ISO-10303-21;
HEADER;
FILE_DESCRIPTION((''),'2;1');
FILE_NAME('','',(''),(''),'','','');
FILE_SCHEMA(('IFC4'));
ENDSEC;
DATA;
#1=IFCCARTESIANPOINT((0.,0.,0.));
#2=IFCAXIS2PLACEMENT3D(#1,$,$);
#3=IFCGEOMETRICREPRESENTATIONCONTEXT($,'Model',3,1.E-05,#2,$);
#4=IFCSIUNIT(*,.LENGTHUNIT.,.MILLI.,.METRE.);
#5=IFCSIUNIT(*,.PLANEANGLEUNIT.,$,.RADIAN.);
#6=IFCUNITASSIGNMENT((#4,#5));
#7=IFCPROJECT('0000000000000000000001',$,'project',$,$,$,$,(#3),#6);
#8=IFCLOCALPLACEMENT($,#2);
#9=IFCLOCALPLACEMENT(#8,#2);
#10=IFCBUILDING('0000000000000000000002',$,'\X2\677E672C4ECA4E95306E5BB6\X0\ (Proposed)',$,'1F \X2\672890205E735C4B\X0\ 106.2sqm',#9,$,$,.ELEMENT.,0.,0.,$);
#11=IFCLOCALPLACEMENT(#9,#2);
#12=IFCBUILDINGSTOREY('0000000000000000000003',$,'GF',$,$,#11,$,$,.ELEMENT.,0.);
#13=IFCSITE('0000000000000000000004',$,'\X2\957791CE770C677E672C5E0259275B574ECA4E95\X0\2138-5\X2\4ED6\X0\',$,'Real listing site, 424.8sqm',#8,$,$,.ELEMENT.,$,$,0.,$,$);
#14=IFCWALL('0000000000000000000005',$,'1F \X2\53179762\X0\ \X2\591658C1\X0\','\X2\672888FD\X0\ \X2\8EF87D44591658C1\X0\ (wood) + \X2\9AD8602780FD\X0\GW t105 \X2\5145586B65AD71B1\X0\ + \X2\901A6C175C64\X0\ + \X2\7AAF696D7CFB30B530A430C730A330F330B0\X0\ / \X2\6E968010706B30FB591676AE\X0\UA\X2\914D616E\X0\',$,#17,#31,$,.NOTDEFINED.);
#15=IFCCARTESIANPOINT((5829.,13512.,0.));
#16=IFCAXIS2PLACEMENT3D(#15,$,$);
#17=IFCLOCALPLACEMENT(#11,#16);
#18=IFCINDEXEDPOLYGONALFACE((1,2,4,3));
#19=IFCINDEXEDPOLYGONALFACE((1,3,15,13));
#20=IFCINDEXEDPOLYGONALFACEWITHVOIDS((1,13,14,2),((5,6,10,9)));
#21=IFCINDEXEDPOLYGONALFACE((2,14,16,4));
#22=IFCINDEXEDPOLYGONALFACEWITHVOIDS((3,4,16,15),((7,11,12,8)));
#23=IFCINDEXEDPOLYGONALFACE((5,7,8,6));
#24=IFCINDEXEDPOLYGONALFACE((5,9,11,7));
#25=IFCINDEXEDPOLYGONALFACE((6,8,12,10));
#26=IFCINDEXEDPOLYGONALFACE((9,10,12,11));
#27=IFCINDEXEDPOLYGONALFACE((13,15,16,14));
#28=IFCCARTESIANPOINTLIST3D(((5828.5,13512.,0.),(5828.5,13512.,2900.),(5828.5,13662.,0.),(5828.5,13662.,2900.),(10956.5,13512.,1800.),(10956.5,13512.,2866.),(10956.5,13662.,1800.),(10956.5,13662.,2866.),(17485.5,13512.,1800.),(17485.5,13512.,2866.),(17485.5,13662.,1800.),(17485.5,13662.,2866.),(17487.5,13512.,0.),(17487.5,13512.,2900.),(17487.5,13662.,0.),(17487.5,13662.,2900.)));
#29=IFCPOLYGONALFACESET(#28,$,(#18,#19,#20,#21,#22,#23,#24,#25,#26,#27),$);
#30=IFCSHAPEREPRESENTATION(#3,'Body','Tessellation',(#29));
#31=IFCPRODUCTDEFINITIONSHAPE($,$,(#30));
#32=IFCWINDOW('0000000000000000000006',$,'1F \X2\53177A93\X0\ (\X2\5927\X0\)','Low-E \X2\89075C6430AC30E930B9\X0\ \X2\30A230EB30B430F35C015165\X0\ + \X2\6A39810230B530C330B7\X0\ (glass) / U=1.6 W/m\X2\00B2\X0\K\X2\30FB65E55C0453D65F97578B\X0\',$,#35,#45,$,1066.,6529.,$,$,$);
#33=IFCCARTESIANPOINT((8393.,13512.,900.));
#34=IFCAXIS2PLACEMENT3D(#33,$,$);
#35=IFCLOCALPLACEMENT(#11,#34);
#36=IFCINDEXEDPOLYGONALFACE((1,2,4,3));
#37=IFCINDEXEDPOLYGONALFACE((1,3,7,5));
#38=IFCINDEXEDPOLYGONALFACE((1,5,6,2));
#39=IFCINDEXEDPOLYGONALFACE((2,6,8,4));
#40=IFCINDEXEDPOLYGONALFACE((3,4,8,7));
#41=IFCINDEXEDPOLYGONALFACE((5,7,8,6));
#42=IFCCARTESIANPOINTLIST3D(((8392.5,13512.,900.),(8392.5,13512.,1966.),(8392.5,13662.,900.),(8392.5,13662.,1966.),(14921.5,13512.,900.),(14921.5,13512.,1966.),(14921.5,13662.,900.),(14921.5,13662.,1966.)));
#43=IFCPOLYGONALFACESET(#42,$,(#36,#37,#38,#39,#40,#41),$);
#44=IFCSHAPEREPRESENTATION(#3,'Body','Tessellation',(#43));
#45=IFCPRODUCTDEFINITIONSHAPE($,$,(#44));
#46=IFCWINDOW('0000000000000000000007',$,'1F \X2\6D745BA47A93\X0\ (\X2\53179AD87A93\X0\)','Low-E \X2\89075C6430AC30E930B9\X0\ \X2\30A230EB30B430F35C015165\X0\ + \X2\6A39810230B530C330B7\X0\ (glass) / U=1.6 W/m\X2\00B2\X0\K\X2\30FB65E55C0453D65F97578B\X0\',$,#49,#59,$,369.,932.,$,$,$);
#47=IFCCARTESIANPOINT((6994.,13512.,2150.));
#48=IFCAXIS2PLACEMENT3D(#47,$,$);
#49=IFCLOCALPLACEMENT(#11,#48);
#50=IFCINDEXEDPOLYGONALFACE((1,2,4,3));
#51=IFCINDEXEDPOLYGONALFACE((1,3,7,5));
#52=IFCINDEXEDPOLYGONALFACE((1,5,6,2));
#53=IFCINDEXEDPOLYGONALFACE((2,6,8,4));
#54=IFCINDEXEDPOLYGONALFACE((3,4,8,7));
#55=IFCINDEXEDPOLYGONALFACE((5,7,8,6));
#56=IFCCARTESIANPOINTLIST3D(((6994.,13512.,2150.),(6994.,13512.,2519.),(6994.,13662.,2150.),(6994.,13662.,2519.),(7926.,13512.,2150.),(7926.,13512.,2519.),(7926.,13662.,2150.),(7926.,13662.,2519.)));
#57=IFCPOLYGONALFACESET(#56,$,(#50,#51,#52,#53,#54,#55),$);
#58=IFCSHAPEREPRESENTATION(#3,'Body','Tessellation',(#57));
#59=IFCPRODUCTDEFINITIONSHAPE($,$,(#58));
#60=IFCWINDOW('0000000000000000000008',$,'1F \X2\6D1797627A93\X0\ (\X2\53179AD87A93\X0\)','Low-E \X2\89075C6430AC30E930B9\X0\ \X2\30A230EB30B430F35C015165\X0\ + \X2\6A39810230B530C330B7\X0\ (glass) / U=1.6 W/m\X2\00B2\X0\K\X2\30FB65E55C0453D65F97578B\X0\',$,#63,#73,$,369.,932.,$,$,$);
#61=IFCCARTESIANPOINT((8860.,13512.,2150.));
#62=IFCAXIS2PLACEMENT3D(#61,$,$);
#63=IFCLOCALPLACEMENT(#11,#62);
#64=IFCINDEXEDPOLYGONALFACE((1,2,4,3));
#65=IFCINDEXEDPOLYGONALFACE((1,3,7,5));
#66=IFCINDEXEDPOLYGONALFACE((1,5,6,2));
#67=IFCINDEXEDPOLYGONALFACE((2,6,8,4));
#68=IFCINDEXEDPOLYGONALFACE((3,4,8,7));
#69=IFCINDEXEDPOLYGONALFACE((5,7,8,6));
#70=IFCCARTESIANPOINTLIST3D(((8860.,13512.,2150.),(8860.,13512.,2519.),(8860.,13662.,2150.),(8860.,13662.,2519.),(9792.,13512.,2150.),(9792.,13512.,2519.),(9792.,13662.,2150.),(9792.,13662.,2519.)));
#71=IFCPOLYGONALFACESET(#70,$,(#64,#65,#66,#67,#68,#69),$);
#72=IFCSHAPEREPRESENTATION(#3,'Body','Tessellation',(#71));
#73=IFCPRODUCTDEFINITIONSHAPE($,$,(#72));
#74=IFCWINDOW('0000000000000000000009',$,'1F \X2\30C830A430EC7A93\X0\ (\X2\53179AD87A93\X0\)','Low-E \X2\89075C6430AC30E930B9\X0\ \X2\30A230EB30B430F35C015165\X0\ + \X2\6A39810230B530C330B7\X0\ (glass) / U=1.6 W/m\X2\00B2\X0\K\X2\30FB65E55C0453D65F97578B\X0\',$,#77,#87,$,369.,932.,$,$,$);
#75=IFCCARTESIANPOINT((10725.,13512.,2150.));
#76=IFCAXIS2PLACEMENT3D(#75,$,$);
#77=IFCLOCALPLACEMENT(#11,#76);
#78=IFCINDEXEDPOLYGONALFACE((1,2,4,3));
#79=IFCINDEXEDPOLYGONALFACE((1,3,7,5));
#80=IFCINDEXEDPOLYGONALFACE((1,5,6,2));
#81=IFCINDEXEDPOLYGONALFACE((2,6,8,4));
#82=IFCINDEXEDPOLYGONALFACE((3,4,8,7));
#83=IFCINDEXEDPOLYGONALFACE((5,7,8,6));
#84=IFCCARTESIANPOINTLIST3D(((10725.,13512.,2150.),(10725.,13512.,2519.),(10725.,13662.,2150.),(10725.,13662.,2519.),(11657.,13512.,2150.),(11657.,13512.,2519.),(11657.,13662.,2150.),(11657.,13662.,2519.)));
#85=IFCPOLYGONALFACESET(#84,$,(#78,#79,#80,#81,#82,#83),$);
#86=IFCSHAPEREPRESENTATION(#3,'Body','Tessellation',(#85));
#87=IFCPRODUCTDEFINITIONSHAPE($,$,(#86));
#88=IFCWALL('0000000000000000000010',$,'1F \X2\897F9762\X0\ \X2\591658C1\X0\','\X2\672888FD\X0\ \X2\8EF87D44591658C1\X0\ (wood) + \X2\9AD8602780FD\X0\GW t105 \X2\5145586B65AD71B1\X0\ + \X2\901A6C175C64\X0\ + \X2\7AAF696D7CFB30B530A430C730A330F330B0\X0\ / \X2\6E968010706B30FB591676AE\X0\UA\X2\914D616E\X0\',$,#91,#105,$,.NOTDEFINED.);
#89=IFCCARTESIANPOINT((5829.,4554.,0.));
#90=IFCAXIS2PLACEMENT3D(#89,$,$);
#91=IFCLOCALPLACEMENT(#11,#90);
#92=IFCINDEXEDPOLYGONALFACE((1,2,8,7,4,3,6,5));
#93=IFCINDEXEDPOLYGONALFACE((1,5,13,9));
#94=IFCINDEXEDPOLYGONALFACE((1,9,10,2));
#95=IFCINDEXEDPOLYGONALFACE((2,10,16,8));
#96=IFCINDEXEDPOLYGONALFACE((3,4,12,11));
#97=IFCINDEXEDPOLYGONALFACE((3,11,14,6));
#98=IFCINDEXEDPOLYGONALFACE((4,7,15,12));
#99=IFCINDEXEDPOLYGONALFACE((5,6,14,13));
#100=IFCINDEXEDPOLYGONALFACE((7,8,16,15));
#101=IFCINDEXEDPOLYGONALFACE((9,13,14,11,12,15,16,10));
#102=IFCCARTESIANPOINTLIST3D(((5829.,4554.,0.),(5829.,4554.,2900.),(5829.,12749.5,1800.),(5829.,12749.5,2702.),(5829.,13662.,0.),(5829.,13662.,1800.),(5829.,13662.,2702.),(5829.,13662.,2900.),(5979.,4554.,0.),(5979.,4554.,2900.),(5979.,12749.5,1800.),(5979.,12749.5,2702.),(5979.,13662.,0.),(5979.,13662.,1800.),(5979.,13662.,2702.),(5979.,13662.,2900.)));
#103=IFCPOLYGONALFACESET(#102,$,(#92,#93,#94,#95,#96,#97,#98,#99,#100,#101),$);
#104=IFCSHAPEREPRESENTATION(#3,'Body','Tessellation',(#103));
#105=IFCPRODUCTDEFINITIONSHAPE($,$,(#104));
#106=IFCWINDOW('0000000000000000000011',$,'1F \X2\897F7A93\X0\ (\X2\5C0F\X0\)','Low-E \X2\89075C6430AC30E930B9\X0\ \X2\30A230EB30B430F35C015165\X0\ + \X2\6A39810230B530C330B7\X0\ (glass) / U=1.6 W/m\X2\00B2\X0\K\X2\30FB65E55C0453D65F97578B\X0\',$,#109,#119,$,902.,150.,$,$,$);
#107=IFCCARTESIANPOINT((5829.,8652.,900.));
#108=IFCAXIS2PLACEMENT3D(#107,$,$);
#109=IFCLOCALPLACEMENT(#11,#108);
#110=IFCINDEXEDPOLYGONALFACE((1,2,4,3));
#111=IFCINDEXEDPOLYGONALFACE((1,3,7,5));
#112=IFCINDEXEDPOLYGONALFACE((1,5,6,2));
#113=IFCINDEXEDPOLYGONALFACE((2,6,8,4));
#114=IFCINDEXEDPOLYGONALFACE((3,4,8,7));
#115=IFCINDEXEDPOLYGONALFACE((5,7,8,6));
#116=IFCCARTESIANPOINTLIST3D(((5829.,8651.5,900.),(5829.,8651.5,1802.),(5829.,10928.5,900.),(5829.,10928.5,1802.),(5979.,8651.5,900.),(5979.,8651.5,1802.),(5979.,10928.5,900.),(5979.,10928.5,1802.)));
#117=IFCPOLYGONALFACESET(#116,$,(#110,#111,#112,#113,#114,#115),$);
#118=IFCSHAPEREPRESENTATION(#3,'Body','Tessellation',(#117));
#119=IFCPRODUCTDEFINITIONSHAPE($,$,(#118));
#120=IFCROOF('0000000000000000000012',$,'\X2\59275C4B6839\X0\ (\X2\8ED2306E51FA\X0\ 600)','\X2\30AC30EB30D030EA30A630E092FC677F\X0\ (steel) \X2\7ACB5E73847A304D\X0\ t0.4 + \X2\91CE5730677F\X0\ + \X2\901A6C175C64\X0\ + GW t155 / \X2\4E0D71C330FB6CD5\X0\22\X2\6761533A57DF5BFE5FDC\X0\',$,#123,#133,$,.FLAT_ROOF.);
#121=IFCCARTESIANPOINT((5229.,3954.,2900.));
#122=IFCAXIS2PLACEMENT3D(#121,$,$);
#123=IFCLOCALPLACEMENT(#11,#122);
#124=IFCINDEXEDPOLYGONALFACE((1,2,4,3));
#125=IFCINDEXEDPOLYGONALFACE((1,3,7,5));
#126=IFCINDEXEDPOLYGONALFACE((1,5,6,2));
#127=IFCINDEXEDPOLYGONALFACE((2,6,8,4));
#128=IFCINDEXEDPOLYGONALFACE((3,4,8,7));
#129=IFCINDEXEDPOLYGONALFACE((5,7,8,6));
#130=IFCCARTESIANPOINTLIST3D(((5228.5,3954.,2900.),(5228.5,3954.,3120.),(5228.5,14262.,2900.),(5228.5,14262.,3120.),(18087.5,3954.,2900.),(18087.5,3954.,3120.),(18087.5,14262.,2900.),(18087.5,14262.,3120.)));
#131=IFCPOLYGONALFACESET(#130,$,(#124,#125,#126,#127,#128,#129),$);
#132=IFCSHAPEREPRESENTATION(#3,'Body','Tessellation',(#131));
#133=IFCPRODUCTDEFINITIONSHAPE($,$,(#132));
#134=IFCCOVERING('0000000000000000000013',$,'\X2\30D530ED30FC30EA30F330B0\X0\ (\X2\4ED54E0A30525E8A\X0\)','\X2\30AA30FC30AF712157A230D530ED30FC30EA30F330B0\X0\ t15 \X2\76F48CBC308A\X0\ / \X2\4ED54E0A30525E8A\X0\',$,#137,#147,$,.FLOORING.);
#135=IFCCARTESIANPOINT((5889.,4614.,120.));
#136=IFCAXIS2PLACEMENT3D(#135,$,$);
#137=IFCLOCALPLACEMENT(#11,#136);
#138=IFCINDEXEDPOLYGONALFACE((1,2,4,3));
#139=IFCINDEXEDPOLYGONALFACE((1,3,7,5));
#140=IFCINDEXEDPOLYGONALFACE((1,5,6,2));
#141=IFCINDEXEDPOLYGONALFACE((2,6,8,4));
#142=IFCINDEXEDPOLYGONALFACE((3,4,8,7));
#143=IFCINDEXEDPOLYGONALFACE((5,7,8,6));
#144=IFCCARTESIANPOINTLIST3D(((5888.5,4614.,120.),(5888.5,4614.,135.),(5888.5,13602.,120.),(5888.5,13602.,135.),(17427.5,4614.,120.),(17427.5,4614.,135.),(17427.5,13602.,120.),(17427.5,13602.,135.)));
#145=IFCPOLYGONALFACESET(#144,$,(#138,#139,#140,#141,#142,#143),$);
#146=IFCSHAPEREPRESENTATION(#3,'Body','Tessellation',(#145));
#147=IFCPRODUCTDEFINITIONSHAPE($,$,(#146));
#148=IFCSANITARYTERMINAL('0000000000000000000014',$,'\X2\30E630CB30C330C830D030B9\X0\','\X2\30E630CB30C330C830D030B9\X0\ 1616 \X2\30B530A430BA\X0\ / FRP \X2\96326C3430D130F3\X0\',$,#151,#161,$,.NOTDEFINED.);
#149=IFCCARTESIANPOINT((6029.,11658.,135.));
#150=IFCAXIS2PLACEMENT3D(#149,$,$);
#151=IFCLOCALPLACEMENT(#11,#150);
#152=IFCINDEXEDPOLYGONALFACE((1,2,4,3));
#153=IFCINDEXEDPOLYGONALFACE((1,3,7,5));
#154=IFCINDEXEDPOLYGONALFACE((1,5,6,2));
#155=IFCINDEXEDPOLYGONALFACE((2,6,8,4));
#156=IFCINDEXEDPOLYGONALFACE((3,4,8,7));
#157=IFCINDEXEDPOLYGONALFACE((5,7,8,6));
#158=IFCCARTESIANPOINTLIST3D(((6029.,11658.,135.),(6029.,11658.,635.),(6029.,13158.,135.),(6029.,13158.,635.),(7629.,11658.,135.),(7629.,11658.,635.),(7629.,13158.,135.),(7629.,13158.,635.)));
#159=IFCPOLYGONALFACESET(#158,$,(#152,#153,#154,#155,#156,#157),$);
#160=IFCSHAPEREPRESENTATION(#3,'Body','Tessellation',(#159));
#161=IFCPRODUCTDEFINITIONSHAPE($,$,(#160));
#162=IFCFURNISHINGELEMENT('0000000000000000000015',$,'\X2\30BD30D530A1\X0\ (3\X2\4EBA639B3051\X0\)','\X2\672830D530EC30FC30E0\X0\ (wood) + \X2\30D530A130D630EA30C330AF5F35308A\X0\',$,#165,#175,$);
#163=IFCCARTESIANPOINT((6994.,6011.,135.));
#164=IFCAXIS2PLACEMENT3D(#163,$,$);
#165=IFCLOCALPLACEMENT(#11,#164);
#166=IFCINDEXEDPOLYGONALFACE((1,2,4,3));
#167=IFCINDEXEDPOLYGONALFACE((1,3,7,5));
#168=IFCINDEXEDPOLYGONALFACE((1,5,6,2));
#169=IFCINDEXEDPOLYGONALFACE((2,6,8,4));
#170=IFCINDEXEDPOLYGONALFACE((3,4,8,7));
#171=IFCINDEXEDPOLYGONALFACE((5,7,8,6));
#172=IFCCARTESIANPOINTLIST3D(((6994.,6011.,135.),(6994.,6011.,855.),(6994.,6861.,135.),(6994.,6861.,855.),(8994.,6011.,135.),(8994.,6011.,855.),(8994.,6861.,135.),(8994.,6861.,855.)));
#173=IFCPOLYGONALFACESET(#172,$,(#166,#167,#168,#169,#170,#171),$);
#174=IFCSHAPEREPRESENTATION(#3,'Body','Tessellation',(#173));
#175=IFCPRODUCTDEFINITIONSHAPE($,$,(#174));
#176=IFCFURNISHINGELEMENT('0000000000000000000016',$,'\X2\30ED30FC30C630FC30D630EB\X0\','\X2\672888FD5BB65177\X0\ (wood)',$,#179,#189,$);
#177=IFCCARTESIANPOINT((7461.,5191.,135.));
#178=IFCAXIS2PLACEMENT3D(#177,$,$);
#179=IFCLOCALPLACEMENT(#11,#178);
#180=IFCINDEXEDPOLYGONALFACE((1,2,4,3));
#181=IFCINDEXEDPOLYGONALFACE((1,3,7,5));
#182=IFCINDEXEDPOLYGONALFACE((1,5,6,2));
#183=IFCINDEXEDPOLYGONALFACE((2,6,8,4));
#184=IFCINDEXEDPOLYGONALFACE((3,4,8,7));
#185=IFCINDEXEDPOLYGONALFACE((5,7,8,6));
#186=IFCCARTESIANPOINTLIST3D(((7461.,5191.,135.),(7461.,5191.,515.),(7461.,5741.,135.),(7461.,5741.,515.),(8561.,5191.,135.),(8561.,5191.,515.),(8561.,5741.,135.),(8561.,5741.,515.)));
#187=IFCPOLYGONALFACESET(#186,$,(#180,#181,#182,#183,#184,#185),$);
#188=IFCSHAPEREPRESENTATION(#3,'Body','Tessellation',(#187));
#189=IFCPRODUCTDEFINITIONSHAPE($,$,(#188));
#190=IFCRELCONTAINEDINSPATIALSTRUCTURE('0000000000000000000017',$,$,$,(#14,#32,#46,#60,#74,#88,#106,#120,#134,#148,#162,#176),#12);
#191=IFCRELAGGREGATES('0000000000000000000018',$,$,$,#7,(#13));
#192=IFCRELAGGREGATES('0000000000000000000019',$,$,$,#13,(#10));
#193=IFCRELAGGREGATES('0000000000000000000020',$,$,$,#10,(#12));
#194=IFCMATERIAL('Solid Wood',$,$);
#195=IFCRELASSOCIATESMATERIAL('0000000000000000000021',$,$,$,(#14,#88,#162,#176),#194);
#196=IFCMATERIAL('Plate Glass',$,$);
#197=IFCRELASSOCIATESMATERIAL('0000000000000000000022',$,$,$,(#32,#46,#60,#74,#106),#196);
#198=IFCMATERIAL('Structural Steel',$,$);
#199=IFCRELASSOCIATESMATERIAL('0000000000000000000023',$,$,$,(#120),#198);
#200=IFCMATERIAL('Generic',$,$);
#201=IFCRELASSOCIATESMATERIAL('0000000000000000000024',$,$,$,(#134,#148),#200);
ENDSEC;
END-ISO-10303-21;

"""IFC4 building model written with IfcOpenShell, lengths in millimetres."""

from ifc_helpers import new_model, si_unit, frame, frame_2d, origin, place, context, project, spatial, rectangle, extrude, material, element, fill, save


model = new_model("IFC4")

# Units and contexts
model_context = context("Model", 3, precision=1e-05, world=origin())
ifc_project = project(units=[si_unit("LENGTHUNIT", "METRE", prefix="MILLI"), si_unit("PLANEANGLEUNIT", "RADIAN")], contexts=[model_context])

# Site, building, storey
site_placement = place(None, origin())
site = spatial("IfcSite", under=ifc_project, at=site_placement, Name="長野県松本市大字今井2138-5他", ObjectType="Real listing site, 424.8sqm", CompositionType="ELEMENT", RefElevation=0.0)
building_placement = place(site_placement, origin())
building = spatial("IfcBuilding", under=site, at=building_placement, Name="松本今井の家 (Proposed)", ObjectType="1F 木造平屋 106.2sqm", CompositionType="ELEMENT", ElevationOfRefHeight=0.0, ElevationOfTerrain=0.0)
storey_placement = place(building_placement, origin())
storey = spatial("IfcBuildingStorey", under=building, at=storey_placement, Name="GF", CompositionType="ELEMENT", Elevation=0.0)

# Shared definitions
ifc_material_1 = material(Name="Solid Wood")

# Shared definitions
ifc_material_2 = material(Name="Plate Glass")

# Wall, openings, windows
wall_1_placement = place(storey_placement, frame((5829.0, 13512.0, 0.0)))
wall_1 = element("IfcWall", 1, at=wall_1_placement, inside=storey, material=ifc_material_1, Name="1F 北面 外壁", Description="木製 軸組外壁 (wood) + 高性能GW t105 充填断熱 + 通気層 + 窯業系サイディング / 準耐火・外皮UA配慮", PredefinedType="NOTDEFINED", context=model_context, shape_type="SweptSolid", body=[
    extrude(rectangle(XDim=11659.0, YDim=150.0, at=frame_2d((5829.0, 75.0))), frame((5829.0, 13512.0, 0.0)), (0.0, 0.0, 1.0), 2900.0),
])
opening_1_placement = place(storey_placement, frame((8393.0, 13512.0, 900.0)))
opening_1 = element("IfcOpeningElement", 2, at=opening_1_placement, cuts=wall_1, PredefinedType="NOTDEFINED", context=model_context, shape_type="SweptSolid", body=[
    extrude(rectangle(XDim=6529.0, YDim=150.0, at=frame_2d((3264.0, 75.0))), frame((8393.0, 13512.0, 900.0)), (0.0, 0.0, 1.0), 1066.0),
])
opening_2_placement = place(storey_placement, frame((6994.0, 13512.0, 2150.0)))
opening_2 = element("IfcOpeningElement", 3, at=opening_2_placement, cuts=wall_1, PredefinedType="NOTDEFINED", context=model_context, shape_type="SweptSolid", body=[
    extrude(rectangle(XDim=932.0, YDim=150.0, at=frame_2d((466.0, 75.0))), frame((6994.0, 13512.0, 2150.0)), (0.0, 0.0, 1.0), 369.0),
])
opening_3_placement = place(storey_placement, frame((8860.0, 13512.0, 2150.0)))
opening_3 = element("IfcOpeningElement", 4, at=opening_3_placement, cuts=wall_1, PredefinedType="NOTDEFINED", context=model_context, shape_type="SweptSolid", body=[
    extrude(rectangle(XDim=932.0, YDim=150.0, at=frame_2d((466.0, 75.0))), frame((8860.0, 13512.0, 2150.0)), (0.0, 0.0, 1.0), 369.0),
])
opening_4_placement = place(storey_placement, frame((10725.0, 13512.0, 2150.0)))
opening_4 = element("IfcOpeningElement", 5, at=opening_4_placement, cuts=wall_1, PredefinedType="NOTDEFINED", context=model_context, shape_type="SweptSolid", body=[
    extrude(rectangle(XDim=932.0, YDim=150.0, at=frame_2d((466.0, 75.0))), frame((10725.0, 13512.0, 2150.0)), (0.0, 0.0, 1.0), 369.0),
])
window_1_placement = place(storey_placement, frame((8393.0, 13512.0, 900.0)))
window_1 = element("IfcWindow", 6, at=window_1_placement, inside=storey, material=ifc_material_2, Name="1F 北窓 (大)", Description="Low-E 複層ガラス アルゴン封入 + 樹脂サッシ (glass) / U=1.6 W/m²K・日射取得型", OverallHeight=1066.0, OverallWidth=6529.0, context=model_context, shape_type="SweptSolid", body=[
    extrude(rectangle(XDim=6529.0, YDim=150.0, at=frame_2d((3264.0, 75.0))), frame((8393.0, 13512.0, 900.0)), (0.0, 0.0, 1.0), 1066.0),
])
fill(opening_1, window_1)
window_2_placement = place(storey_placement, frame((6994.0, 13512.0, 2150.0)))
window_2 = element("IfcWindow", 7, at=window_2_placement, inside=storey, material=ifc_material_2, Name="1F 浴室窓 (北高窓)", Description="Low-E 複層ガラス アルゴン封入 + 樹脂サッシ (glass) / U=1.6 W/m²K・日射取得型", OverallHeight=369.0, OverallWidth=932.0, context=model_context, shape_type="SweptSolid", body=[
    extrude(rectangle(XDim=932.0, YDim=150.0, at=frame_2d((466.0, 75.0))), frame((6994.0, 13512.0, 2150.0)), (0.0, 0.0, 1.0), 369.0),
])
fill(opening_2, window_2)
window_3_placement = place(storey_placement, frame((8860.0, 13512.0, 2150.0)))
window_3 = element("IfcWindow", 8, at=window_3_placement, inside=storey, material=ifc_material_2, Name="1F 洗面窓 (北高窓)", Description="Low-E 複層ガラス アルゴン封入 + 樹脂サッシ (glass) / U=1.6 W/m²K・日射取得型", OverallHeight=369.0, OverallWidth=932.0, context=model_context, shape_type="SweptSolid", body=[
    extrude(rectangle(XDim=932.0, YDim=150.0, at=frame_2d((466.0, 75.0))), frame((8860.0, 13512.0, 2150.0)), (0.0, 0.0, 1.0), 369.0),
])
fill(opening_3, window_3)
window_4_placement = place(storey_placement, frame((10725.0, 13512.0, 2150.0)))
window_4 = element("IfcWindow", 9, at=window_4_placement, inside=storey, material=ifc_material_2, Name="1F トイレ窓 (北高窓)", Description="Low-E 複層ガラス アルゴン封入 + 樹脂サッシ (glass) / U=1.6 W/m²K・日射取得型", OverallHeight=369.0, OverallWidth=932.0, context=model_context, shape_type="SweptSolid", body=[
    extrude(rectangle(XDim=932.0, YDim=150.0, at=frame_2d((466.0, 75.0))), frame((10725.0, 13512.0, 2150.0)), (0.0, 0.0, 1.0), 369.0),
])
fill(opening_4, window_4)

# Wall, opening, window
wall_2_placement = place(storey_placement, frame((5829.0, 4554.0, 0.0)))
wall_2 = element("IfcWall", 10, at=wall_2_placement, inside=storey, material=ifc_material_1, Name="1F 西面 外壁", Description="木製 軸組外壁 (wood) + 高性能GW t105 充填断熱 + 通気層 + 窯業系サイディング / 準耐火・外皮UA配慮", PredefinedType="NOTDEFINED", context=model_context, shape_type="SweptSolid", body=[
    extrude(rectangle(XDim=150.0, YDim=9108.0, at=frame_2d((75.0, 4554.0))), frame((5829.0, 4554.0, 0.0)), (0.0, 0.0, 1.0), 2900.0),
])
opening_5_placement = place(storey_placement, frame((5829.0, 8652.0, 900.0)))
opening_5 = element("IfcOpeningElement", 11, at=opening_5_placement, cuts=wall_2, PredefinedType="NOTDEFINED", context=model_context, shape_type="SweptSolid", body=[
    extrude(rectangle(XDim=150.0, YDim=2277.0, at=frame_2d((75.0, 1138.0))), frame((5829.0, 8652.0, 900.0)), (0.0, 0.0, 1.0), 902.0),
])
window_5_placement = place(storey_placement, frame((5829.0, 8652.0, 900.0)))
window_5 = element("IfcWindow", 12, at=window_5_placement, inside=storey, material=ifc_material_2, Name="1F 西窓 (小)", Description="Low-E 複層ガラス アルゴン封入 + 樹脂サッシ (glass) / U=1.6 W/m²K・日射取得型", OverallHeight=902.0, OverallWidth=150.0, context=model_context, shape_type="SweptSolid", body=[
    extrude(rectangle(XDim=150.0, YDim=2277.0, at=frame_2d((75.0, 1138.0))), frame((5829.0, 8652.0, 900.0)), (0.0, 0.0, 1.0), 902.0),
])
fill(opening_5, window_5)

# Roof
ifc_material_3 = material(Name="Structural Steel")
roof_placement = place(storey_placement, frame((5229.0, 3954.0, 2900.0)))
element("IfcRoof", 13, at=roof_placement, inside=storey, material=ifc_material_3, Name="大屋根 (軒の出 600)", Description="ガルバリウム鋼板 (steel) 立平葺き t0.4 + 野地板 + 通気層 + GW t155 / 不燃・法22条区域対応", PredefinedType="FLAT_ROOF", context=model_context, shape_type="SweptSolid", body=[
    extrude(rectangle(XDim=12859.0, YDim=10308.0, at=frame_2d((6429.0, 5154.0))), frame((5229.0, 3954.0, 2900.0)), (0.0, 0.0, 1.0), 220.0),
])

# Covering
ifc_material_4 = material(Name="Generic")
covering_placement = place(storey_placement, frame((5889.0, 4614.0, 120.0)))
element("IfcCovering", 14, at=covering_placement, inside=storey, material=ifc_material_4, Name="フローリング (仕上げ床)", Description="オーク無垢フローリング t15 直貼り / 仕上げ床", PredefinedType="FLOORING", context=model_context, shape_type="SweptSolid", body=[
    extrude(rectangle(XDim=11539.0, YDim=8988.0, at=frame_2d((5769.0, 4494.0))), frame((5889.0, 4614.0, 120.0)), (0.0, 0.0, 1.0), 15.0),
])

# Sanitary terminal
sanitary_terminal_placement = place(storey_placement, frame((6029.0, 11658.0, 135.0)))
element("IfcSanitaryTerminal", 15, at=sanitary_terminal_placement, inside=storey, material=ifc_material_4, Name="ユニットバス", Description="ユニットバス 1616 サイズ / FRP 防水パン", PredefinedType="NOTDEFINED", context=model_context, shape_type="SweptSolid", body=[
    extrude(rectangle(XDim=1600.0, YDim=1500.0, at=frame_2d((800.0, 750.0))), frame((6029.0, 11658.0, 135.0)), (0.0, 0.0, 1.0), 500.0),
])

# Furnishing elements
furnishing_1_placement = place(storey_placement, frame((6994.0, 6011.0, 135.0)))
element("IfcFurnishingElement", 16, at=furnishing_1_placement, inside=storey, material=ifc_material_1, Name="ソファ (3人掛け)", Description="木フレーム (wood) + ファブリック張り", context=model_context, shape_type="SweptSolid", body=[
    extrude(rectangle(XDim=2000.0, YDim=850.0, at=frame_2d((1000.0, 425.0))), frame((6994.0, 6011.0, 135.0)), (0.0, 0.0, 1.0), 720.0),
])
furnishing_2_placement = place(storey_placement, frame((7461.0, 5191.0, 135.0)))
element("IfcFurnishingElement", 17, at=furnishing_2_placement, inside=storey, material=ifc_material_1, Name="ローテーブル", Description="木製家具 (wood)", context=model_context, shape_type="SweptSolid", body=[
    extrude(rectangle(XDim=1100.0, YDim=550.0, at=frame_2d((550.0, 275.0))), frame((7461.0, 5191.0, 135.0)), (0.0, 0.0, 1.0), 380.0),
])

save(model, "model.ifc")
